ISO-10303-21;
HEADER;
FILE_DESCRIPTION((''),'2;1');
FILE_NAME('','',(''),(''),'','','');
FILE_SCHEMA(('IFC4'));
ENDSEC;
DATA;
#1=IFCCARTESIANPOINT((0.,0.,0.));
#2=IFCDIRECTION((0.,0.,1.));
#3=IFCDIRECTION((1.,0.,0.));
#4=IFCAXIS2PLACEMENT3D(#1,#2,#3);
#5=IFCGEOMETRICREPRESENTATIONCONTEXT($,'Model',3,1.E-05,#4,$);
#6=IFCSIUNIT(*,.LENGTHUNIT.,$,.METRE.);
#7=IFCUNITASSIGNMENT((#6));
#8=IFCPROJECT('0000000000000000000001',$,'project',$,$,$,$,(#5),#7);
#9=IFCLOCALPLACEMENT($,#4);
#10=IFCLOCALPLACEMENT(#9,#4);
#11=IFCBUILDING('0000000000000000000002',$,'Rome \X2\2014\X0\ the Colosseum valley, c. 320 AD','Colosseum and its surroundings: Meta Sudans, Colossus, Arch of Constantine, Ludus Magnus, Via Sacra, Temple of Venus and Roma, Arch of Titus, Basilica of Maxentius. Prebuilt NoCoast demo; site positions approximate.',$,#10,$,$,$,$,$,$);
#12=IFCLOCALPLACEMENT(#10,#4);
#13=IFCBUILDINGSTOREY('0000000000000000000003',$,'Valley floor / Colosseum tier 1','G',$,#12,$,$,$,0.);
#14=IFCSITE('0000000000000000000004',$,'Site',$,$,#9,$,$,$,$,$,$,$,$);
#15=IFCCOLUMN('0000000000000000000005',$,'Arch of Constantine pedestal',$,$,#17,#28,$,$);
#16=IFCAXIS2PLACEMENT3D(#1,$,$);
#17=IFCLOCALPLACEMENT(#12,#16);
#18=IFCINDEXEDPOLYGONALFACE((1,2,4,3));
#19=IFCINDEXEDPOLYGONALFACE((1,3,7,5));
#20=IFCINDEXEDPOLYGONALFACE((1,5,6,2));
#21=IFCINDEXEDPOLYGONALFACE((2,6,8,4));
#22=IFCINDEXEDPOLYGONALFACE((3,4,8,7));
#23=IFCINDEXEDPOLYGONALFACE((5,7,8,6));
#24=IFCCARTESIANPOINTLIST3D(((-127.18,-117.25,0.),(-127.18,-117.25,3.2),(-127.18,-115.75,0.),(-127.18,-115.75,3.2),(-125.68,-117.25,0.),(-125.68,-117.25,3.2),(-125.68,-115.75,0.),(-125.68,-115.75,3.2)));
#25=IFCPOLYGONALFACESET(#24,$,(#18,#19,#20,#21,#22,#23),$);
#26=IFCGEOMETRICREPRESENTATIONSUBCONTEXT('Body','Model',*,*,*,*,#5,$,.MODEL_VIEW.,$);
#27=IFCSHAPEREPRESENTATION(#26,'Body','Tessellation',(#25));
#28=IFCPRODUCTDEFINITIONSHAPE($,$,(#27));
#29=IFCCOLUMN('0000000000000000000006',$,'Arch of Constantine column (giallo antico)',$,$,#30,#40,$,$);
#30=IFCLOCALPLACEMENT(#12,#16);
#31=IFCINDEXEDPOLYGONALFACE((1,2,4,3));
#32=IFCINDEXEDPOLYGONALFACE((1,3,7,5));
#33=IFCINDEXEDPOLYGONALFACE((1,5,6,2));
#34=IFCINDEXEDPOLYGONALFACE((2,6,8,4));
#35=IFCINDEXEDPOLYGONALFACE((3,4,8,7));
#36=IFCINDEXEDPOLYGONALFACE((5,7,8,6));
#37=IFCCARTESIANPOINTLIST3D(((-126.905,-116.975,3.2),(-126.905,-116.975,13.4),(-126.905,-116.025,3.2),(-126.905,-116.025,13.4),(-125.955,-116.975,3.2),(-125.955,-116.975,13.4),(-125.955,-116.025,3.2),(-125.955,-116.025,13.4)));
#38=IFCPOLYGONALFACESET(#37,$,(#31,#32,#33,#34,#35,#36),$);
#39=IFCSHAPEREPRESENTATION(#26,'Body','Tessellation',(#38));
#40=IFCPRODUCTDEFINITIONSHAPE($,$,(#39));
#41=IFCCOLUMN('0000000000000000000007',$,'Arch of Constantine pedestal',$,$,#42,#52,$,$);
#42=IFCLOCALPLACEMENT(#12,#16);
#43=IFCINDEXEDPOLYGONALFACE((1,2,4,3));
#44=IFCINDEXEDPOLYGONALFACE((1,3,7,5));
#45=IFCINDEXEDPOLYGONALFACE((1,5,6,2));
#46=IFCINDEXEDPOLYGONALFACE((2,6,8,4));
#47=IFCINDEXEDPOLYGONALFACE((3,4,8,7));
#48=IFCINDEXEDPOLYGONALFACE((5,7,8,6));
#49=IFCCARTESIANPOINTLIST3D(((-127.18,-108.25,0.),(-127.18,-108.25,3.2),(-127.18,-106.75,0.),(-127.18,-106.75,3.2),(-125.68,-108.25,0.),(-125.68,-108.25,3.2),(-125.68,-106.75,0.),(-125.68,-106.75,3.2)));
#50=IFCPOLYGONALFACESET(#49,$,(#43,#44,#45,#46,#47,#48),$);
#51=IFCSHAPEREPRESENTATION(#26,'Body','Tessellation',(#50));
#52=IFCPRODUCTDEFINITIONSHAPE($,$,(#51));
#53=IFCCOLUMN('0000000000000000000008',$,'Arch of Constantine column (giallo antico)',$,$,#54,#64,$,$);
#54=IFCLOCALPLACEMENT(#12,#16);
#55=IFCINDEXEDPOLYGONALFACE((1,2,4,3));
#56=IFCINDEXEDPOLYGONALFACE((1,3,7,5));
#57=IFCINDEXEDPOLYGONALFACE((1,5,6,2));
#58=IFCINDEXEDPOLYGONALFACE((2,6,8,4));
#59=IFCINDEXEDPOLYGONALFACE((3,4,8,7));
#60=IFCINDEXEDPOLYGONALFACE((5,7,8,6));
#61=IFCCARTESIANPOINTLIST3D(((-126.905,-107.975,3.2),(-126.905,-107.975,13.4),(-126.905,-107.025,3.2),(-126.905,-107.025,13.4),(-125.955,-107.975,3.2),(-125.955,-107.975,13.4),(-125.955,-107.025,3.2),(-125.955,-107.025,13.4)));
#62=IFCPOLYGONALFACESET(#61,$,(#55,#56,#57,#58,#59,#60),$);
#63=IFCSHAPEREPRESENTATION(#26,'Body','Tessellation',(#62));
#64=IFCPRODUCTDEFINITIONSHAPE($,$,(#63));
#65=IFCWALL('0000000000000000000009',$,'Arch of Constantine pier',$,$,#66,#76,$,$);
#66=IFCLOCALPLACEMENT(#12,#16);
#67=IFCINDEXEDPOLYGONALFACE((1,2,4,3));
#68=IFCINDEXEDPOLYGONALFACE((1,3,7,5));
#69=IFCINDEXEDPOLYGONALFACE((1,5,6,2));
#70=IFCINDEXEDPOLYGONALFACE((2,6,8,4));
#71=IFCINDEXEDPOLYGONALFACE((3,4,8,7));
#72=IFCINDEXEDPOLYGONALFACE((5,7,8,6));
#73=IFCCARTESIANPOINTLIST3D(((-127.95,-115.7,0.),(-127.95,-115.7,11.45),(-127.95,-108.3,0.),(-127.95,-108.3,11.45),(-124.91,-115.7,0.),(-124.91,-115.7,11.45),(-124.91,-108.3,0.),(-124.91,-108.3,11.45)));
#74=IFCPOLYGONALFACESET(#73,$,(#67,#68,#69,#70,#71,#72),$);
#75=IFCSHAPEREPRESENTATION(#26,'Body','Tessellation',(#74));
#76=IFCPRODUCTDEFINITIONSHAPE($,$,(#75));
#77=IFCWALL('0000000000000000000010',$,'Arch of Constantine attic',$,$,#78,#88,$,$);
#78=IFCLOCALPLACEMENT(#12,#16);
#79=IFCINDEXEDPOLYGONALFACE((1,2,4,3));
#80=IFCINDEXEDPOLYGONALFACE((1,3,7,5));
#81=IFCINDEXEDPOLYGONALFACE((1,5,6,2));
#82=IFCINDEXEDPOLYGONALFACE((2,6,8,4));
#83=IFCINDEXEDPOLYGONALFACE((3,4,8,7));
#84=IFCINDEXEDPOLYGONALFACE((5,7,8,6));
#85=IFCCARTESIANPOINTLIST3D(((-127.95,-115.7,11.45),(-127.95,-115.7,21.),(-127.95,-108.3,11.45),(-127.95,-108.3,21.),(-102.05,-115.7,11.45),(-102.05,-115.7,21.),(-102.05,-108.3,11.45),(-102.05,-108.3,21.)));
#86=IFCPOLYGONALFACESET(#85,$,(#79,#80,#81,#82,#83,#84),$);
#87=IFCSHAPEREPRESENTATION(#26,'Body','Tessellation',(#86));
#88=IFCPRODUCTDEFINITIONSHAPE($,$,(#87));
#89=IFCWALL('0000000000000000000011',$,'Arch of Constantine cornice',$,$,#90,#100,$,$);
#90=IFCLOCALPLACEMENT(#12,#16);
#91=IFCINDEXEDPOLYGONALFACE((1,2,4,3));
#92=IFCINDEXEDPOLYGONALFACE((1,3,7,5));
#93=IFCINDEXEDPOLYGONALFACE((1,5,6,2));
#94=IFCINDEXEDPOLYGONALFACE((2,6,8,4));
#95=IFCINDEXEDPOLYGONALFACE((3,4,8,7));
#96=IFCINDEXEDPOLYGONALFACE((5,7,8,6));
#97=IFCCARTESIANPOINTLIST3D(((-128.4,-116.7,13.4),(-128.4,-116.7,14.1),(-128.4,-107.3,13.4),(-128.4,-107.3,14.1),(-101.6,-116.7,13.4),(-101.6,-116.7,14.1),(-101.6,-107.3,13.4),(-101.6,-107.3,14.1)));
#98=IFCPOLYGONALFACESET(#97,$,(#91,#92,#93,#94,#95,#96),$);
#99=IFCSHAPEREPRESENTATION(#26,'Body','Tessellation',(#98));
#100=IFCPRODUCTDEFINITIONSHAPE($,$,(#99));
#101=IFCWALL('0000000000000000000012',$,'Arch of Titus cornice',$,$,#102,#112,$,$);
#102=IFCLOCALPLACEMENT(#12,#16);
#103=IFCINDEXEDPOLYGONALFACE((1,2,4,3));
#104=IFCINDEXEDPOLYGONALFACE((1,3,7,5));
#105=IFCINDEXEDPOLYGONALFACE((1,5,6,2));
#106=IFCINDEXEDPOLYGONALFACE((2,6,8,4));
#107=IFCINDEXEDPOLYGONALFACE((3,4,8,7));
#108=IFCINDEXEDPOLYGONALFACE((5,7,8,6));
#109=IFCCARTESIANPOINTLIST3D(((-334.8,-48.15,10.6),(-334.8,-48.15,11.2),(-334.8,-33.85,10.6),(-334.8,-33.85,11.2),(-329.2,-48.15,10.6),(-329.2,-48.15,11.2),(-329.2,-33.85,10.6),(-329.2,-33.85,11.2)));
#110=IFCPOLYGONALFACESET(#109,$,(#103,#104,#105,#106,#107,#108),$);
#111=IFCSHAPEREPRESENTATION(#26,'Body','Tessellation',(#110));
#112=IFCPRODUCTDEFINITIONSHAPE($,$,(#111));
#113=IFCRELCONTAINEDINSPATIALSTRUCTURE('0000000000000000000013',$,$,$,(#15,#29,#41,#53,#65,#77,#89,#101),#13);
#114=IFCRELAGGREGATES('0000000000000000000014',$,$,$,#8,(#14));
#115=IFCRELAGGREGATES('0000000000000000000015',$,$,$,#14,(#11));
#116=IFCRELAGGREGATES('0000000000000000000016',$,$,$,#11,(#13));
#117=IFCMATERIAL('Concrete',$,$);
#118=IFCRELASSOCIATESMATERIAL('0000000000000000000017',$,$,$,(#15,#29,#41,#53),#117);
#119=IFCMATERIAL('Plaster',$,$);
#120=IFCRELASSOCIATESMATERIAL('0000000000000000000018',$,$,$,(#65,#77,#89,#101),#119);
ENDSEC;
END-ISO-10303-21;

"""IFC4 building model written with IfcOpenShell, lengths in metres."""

from ifc_helpers import new_model, si_unit, frame, origin_with_axes, place, context, subcontext, project, spatial, indexed_curve, outline, extrude, material, element, save


model = new_model("IFC4")

# Units and contexts
model_context = context("Model", 3, precision=1e-05, world=origin_with_axes())
body_context = subcontext(model_context, "Body", "Model", "MODEL_VIEW")
ifc_project = project(units=[si_unit("LENGTHUNIT", "METRE")], contexts=[model_context])

# Site, building, storey
site_placement = place(None, origin_with_axes())
site = spatial("IfcSite", under=ifc_project, at=site_placement, Name="Site")
building_placement = place(site_placement, origin_with_axes())
building = spatial("IfcBuilding", under=site, at=building_placement, Name="Rome — the Colosseum valley, c. 320 AD", Description="Colosseum and its surroundings: Meta Sudans, Colossus, Arch of Constantine, Ludus Magnus, Via Sacra, Temple of Venus and Roma, Arch of Titus, Basilica of Maxentius. Prebuilt NoCoast demo; site positions approximate.")
storey_placement = place(building_placement, origin_with_axes())
storey = spatial("IfcBuildingStorey", under=building, at=storey_placement, Name="Valley floor / Colosseum tier 1", Description="G", Elevation=0.0)

# Columns
ifc_material_1 = material(Name="Concrete")
column_1_placement = place(storey_placement, frame((-127.18, -116.5, 0.0), z_axis=(0.0, 0.0, 1.0), x_axis=(1.0, 0.0, 0.0)))
element("IfcColumn", 1, at=column_1_placement, inside=storey, material=ifc_material_1, Name="Arch of Constantine pedestal", context=body_context, shape_type="SweptSolid", body=[
    extrude(outline(indexed_curve([(0.0, 0.0), (0.0, 1.5), (1.5, 1.5), (1.5, 0.0), (0.0, 0.0)], self_intersect=False)), frame((0.0, -0.75, 0.0), z_axis=(0.0, 0.0, 1.0), x_axis=(1.0, 0.0, 0.0)), (0.0, 0.0, 1.0), 3.2),
])
column_2_placement = place(storey_placement, frame((-126.905, -116.5, 3.2), z_axis=(0.0, 0.0, 1.0), x_axis=(1.0, 0.0, 0.0)))
element("IfcColumn", 2, at=column_2_placement, inside=storey, material=ifc_material_1, Name="Arch of Constantine column (giallo antico)", context=body_context, shape_type="SweptSolid", body=[
    extrude(outline(indexed_curve([(0.0, 0.0), (0.0, 0.95), (0.95, 0.95), (0.95, 0.0), (0.0, 0.0)], self_intersect=False)), frame((0.0, -0.475, 0.0), z_axis=(0.0, 0.0, 1.0), x_axis=(1.0, 0.0, 0.0)), (0.0, 0.0, 1.0), 10.2),
])
column_3_placement = place(storey_placement, frame((-127.18, -107.5, 0.0), z_axis=(0.0, 0.0, 1.0), x_axis=(1.0, 0.0, 0.0)))
element("IfcColumn", 3, at=column_3_placement, inside=storey, material=ifc_material_1, Name="Arch of Constantine pedestal", context=body_context, shape_type="SweptSolid", body=[
    extrude(outline(indexed_curve([(0.0, 0.0), (0.0, 1.5), (1.5, 1.5), (1.5, 0.0), (0.0, 0.0)], self_intersect=False)), frame((0.0, -0.75, 0.0), z_axis=(0.0, 0.0, 1.0), x_axis=(1.0, 0.0, 0.0)), (0.0, 0.0, 1.0), 3.2),
])
column_4_placement = place(storey_placement, frame((-126.905, -107.5, 3.2), z_axis=(0.0, 0.0, 1.0), x_axis=(1.0, 0.0, 0.0)))
element("IfcColumn", 4, at=column_4_placement, inside=storey, material=ifc_material_1, Name="Arch of Constantine column (giallo antico)", context=body_context, shape_type="SweptSolid", body=[
    extrude(outline(indexed_curve([(0.0, 0.0), (0.0, 0.95), (0.95, 0.95), (0.95, 0.0), (0.0, 0.0)], self_intersect=False)), frame((0.0, -0.475, 0.0), z_axis=(0.0, 0.0, 1.0), x_axis=(1.0, 0.0, 0.0)), (0.0, 0.0, 1.0), 10.2),
])

# Walls
ifc_material_2 = material(Name="Plaster")
wall_1_placement = place(storey_placement, frame((-127.95, -112.0, 0.0), z_axis=(0.0, 0.0, 1.0), x_axis=(1.0, 0.0, 0.0)))
element("IfcWall", 5, at=wall_1_placement, inside=storey, material=ifc_material_2, Name="Arch of Constantine pier", context=body_context, shape_type="SweptSolid", body=[
    extrude(outline(indexed_curve([(0.0, 0.0), (0.0, 7.4), (3.04, 7.4), (3.04, 0.0), (0.0, 0.0)], self_intersect=False)), frame((0.0, -3.7, 0.0), z_axis=(0.0, 0.0, 1.0), x_axis=(1.0, 0.0, 0.0)), (0.0, 0.0, 1.0), 11.45),
])
wall_2_placement = place(storey_placement, frame((-127.95, -112.0, 11.45), z_axis=(0.0, 0.0, 1.0), x_axis=(1.0, 0.0, 0.0)))
element("IfcWall", 6, at=wall_2_placement, inside=storey, material=ifc_material_2, Name="Arch of Constantine attic", context=body_context, shape_type="SweptSolid", body=[
    extrude(outline(indexed_curve([(0.0, 0.0), (0.0, 7.4), (25.9, 7.4), (25.9, 0.0), (0.0, 0.0)], self_intersect=False)), frame((0.0, -3.7, 0.0), z_axis=(0.0, 0.0, 1.0), x_axis=(1.0, 0.0, 0.0)), (0.0, 0.0, 1.0), 9.55),
])
wall_3_placement = place(storey_placement, frame((-128.4, -112.0, 13.4), z_axis=(0.0, 0.0, 1.0), x_axis=(1.0, 0.0, 0.0)))
element("IfcWall", 7, at=wall_3_placement, inside=storey, material=ifc_material_2, Name="Arch of Constantine cornice", context=body_context, shape_type="SweptSolid", body=[
    extrude(outline(indexed_curve([(0.0, 0.0), (0.0, 9.4), (26.8, 9.4), (26.8, 0.0), (0.0, 0.0)], self_intersect=False)), frame((0.0, -4.7, 0.0), z_axis=(0.0, 0.0, 1.0), x_axis=(1.0, 0.0, 0.0)), (0.0, 0.0, 1.0), 0.7),
])
wall_4_placement = place(storey_placement, frame((-332.0, -48.15, 10.6), z_axis=(0.0, 0.0, 1.0), x_axis=(0.0, 1.0, 0.0)))
element("IfcWall", 8, at=wall_4_placement, inside=storey, material=ifc_material_2, Name="Arch of Titus cornice", context=body_context, shape_type="SweptSolid", body=[
    extrude(outline(indexed_curve([(0.0, 0.0), (0.0, 5.6), (14.3, 5.6), (14.3, 0.0), (0.0, 0.0)], self_intersect=False)), frame((0.0, -2.8, 0.0), z_axis=(0.0, 0.0, 1.0), x_axis=(1.0, 0.0, 0.0)), (0.0, 0.0, 1.0), 0.6),
])

save(model, "model.ifc")
